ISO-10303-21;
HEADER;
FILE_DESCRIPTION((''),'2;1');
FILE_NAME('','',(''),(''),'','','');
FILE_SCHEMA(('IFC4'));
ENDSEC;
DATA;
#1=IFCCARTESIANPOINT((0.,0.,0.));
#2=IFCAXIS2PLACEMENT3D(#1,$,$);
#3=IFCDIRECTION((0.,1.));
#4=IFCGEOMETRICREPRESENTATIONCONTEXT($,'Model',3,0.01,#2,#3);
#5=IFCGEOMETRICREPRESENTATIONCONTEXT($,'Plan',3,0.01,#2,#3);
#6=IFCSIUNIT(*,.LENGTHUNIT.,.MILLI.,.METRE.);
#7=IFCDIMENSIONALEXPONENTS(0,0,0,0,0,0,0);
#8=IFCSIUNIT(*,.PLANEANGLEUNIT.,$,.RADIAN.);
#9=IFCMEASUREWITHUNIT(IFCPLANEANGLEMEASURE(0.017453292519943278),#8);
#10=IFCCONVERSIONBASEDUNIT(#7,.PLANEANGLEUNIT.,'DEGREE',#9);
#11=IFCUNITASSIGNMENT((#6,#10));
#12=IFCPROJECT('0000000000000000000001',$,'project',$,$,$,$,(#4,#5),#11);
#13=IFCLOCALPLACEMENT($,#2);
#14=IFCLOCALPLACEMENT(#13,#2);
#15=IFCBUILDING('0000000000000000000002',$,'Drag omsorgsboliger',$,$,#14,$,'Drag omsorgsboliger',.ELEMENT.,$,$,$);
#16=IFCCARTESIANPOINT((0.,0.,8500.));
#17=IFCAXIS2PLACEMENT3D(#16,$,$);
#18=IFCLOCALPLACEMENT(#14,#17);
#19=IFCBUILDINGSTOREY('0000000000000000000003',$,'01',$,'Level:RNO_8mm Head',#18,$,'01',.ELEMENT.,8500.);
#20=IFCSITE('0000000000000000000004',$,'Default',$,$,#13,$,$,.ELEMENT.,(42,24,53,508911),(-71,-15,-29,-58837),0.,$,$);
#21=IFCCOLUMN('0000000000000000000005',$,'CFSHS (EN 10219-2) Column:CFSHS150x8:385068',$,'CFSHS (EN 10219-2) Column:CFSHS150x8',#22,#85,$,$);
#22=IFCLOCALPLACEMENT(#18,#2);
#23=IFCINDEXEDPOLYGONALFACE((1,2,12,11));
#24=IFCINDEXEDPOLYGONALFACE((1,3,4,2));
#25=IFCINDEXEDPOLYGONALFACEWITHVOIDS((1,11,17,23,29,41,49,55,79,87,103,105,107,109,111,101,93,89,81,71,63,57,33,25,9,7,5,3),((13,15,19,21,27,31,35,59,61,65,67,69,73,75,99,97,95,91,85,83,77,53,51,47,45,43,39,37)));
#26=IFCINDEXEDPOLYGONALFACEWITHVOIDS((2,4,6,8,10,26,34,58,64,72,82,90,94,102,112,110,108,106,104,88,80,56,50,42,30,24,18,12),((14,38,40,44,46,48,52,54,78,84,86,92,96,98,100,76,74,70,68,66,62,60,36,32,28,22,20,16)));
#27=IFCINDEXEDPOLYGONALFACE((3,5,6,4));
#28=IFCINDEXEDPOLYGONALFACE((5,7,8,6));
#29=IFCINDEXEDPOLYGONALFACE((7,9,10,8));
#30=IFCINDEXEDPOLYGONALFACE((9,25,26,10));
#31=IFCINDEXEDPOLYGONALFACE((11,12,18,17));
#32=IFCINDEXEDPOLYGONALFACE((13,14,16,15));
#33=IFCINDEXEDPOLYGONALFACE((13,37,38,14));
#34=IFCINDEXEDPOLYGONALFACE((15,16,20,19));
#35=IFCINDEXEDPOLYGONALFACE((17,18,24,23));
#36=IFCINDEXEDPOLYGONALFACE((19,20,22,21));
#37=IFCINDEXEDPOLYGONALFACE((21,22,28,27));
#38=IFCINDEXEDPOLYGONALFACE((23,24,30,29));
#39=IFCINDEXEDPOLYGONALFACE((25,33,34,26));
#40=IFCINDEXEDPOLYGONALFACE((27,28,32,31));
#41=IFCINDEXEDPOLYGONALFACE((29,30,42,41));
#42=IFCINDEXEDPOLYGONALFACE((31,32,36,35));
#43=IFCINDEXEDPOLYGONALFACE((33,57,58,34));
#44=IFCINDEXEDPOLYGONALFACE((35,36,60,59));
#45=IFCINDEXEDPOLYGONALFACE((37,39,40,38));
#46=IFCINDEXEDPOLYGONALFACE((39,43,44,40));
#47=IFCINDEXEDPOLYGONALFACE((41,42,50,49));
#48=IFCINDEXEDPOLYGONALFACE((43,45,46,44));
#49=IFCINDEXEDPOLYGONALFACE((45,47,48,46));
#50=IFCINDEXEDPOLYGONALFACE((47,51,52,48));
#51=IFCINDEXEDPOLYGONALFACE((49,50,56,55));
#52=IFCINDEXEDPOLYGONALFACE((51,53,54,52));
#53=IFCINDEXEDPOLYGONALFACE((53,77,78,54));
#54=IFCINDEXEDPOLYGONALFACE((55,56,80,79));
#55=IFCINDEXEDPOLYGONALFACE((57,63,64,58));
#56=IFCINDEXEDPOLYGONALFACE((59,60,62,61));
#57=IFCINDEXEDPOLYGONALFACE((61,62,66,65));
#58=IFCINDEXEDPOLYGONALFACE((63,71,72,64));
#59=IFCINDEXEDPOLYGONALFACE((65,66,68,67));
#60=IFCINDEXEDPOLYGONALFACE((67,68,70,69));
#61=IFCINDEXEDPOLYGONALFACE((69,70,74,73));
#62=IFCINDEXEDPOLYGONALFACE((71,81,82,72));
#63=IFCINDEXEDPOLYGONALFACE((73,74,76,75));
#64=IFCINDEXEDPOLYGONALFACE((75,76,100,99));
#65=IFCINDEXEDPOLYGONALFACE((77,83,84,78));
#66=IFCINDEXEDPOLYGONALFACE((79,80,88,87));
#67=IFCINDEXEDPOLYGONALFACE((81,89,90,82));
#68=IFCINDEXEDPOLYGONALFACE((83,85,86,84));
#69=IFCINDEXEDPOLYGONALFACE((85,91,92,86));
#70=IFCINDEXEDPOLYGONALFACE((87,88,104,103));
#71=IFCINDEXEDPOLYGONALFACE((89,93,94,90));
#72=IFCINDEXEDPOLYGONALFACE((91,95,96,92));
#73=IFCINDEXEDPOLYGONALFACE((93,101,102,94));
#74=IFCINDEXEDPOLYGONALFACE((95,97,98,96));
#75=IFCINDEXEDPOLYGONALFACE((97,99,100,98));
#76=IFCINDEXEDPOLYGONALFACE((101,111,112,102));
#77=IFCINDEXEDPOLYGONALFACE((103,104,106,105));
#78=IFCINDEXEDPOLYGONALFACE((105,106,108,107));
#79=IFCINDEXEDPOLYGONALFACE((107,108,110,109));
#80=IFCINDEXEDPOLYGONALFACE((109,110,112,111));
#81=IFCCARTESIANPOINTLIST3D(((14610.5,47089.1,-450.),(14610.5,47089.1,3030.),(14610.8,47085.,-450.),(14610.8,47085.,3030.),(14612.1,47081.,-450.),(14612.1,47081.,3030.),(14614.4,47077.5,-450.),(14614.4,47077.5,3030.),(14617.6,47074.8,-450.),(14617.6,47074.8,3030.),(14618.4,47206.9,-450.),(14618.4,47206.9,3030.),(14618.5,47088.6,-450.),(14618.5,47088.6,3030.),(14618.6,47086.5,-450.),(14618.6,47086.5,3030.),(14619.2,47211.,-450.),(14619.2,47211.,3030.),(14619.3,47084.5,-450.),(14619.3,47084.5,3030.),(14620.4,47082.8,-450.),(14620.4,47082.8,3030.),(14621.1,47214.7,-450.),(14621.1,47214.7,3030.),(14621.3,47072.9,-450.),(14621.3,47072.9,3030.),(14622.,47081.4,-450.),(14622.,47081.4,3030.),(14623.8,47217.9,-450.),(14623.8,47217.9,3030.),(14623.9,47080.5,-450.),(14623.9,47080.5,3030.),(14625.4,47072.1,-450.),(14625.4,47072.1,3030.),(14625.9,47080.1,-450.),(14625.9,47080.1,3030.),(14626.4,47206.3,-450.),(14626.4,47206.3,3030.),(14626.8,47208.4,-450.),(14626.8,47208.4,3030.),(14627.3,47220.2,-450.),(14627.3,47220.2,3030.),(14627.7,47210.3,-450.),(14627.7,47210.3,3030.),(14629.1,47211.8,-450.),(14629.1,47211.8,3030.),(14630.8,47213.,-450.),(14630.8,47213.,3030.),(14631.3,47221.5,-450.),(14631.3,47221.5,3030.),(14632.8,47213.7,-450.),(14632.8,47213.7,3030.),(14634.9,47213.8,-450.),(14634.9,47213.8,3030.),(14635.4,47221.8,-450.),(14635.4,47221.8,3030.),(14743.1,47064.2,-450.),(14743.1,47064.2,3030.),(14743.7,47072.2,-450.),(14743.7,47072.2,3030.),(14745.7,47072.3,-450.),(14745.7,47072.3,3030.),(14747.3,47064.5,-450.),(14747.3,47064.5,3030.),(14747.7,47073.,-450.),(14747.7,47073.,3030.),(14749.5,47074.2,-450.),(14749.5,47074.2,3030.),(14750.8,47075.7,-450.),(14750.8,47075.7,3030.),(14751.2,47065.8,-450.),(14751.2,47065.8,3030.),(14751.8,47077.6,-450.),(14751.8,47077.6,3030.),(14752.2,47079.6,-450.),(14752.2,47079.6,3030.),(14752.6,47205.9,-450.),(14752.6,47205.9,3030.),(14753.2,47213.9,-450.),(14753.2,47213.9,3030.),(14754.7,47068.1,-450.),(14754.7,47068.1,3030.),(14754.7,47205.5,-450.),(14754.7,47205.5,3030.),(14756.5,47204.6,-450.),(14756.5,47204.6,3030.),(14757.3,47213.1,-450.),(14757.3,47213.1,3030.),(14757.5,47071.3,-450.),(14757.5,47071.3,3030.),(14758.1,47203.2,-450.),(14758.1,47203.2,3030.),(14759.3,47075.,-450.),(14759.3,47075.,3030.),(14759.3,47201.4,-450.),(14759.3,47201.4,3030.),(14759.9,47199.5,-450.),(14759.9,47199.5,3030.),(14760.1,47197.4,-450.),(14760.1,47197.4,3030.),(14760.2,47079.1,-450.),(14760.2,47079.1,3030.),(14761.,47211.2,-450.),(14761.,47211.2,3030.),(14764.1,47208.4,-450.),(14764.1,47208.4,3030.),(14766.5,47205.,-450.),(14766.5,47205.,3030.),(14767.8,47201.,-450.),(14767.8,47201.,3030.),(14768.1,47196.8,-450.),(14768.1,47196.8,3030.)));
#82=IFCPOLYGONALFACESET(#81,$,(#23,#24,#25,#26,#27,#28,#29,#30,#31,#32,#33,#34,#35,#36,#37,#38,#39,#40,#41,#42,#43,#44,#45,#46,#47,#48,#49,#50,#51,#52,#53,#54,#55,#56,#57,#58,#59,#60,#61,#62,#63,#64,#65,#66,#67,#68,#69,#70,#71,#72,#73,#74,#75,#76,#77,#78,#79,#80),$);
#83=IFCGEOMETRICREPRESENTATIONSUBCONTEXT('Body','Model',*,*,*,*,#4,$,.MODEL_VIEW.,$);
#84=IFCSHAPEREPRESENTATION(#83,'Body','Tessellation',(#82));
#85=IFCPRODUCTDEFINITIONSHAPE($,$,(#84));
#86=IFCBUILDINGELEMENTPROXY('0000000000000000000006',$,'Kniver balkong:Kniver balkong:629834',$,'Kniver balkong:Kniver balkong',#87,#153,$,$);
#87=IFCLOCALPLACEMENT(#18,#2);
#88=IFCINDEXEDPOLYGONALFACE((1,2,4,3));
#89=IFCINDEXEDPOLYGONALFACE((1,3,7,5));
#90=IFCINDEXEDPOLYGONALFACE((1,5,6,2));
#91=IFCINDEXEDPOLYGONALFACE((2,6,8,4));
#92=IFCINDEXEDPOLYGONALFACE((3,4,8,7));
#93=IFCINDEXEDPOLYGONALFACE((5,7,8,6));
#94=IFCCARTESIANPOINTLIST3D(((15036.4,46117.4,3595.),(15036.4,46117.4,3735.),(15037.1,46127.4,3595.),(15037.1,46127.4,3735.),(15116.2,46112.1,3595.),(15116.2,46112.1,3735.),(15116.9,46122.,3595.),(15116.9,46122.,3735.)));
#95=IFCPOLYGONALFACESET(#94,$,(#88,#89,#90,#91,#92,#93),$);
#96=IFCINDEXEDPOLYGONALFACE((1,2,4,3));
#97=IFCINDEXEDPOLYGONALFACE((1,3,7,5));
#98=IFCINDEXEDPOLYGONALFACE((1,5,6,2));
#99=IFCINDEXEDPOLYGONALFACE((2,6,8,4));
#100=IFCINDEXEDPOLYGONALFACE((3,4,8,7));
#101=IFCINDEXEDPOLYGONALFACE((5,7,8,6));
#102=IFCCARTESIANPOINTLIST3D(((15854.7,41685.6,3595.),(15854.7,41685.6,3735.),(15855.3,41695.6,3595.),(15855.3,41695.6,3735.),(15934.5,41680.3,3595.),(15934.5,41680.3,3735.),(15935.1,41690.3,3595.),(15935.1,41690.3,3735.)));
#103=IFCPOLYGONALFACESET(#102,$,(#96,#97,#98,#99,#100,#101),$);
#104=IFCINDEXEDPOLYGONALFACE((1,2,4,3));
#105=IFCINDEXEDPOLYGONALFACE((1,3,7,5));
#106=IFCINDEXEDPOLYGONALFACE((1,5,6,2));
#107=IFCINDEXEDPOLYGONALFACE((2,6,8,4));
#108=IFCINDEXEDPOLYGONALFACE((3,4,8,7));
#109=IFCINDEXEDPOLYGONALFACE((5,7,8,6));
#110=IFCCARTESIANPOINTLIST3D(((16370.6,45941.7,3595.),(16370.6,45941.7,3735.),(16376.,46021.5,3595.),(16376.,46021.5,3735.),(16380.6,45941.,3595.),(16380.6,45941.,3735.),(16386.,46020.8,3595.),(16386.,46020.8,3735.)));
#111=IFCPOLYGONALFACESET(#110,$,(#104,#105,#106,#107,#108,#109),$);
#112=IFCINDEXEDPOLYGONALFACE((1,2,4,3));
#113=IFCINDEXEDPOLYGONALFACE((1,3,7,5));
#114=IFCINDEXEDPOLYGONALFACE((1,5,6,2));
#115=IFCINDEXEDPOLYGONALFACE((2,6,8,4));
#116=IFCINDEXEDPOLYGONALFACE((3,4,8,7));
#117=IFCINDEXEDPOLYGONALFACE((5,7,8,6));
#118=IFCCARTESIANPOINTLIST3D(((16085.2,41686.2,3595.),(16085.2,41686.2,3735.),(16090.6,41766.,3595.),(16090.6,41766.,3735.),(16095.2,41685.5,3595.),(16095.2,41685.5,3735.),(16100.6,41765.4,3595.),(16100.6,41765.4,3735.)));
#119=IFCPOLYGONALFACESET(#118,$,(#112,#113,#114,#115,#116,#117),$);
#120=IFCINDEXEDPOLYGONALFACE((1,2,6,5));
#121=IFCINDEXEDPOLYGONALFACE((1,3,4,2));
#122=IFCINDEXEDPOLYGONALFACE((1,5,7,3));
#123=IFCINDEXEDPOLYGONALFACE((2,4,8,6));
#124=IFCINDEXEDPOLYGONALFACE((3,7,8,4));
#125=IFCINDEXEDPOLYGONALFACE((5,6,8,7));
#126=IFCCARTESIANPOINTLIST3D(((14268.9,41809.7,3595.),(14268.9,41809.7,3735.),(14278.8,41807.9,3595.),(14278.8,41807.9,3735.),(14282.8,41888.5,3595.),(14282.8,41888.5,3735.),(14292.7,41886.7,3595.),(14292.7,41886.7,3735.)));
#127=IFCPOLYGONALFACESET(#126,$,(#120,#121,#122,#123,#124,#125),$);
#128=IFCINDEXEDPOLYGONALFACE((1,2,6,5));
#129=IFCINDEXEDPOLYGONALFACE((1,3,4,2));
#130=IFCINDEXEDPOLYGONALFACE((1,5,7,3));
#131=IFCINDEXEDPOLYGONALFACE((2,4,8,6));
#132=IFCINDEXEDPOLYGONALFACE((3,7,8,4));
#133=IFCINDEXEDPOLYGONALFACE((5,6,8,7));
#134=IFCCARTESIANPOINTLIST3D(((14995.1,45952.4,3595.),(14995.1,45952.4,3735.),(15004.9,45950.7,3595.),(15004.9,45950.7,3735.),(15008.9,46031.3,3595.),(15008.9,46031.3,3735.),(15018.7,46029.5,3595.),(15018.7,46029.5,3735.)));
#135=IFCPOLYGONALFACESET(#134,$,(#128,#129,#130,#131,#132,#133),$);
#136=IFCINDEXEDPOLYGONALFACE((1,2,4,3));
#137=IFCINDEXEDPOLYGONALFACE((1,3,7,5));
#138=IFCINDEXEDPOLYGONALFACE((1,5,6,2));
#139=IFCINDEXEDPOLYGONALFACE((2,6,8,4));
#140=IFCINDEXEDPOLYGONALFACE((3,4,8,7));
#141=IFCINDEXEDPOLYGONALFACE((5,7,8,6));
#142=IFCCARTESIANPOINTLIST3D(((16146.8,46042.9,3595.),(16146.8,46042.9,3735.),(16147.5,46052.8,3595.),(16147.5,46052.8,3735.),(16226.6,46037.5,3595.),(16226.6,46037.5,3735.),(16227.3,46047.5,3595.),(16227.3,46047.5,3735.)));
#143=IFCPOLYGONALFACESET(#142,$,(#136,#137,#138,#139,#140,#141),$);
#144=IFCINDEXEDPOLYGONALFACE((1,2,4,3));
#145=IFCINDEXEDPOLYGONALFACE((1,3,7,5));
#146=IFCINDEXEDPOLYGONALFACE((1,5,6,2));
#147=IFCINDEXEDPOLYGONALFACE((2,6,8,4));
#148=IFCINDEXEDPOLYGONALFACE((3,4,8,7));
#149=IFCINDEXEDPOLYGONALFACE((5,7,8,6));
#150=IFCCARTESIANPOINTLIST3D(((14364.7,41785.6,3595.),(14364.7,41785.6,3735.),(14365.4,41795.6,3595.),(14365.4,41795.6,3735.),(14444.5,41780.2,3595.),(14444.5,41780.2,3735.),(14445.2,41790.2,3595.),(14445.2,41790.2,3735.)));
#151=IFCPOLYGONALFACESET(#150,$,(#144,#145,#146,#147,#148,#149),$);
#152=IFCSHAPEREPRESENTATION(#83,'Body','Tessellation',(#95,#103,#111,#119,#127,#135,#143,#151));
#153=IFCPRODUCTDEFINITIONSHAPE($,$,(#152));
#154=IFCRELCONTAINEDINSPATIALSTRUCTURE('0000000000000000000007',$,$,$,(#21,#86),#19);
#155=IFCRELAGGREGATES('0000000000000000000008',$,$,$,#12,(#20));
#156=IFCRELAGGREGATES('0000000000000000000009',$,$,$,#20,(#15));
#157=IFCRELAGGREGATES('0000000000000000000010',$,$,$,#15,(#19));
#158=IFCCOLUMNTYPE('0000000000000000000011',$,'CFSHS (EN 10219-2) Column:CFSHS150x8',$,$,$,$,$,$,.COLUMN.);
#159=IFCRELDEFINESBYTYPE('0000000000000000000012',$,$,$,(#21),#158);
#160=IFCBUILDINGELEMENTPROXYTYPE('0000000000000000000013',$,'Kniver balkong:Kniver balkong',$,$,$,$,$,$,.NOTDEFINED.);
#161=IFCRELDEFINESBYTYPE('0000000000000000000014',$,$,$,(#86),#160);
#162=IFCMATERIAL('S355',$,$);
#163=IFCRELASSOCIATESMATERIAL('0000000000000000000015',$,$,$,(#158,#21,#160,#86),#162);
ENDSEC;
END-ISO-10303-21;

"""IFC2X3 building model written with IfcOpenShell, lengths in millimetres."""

from ifc_helpers import new_model, entity, si_unit, converted_unit, direction, frame, frame_2d, origin, place, context, subcontext, project, spatial, polyline, circle_curve, parameter, trimmed, segment, composite_curve, rectangle, outline, extrude, source, transform, mapped, material, type_object, type_shapes, element, save


model = new_model("IFC2X3")

# Units and contexts
model_context = context("Model", 3, precision=0.01, world=origin(), true_north=direction((0.0, 1.0)))
plan_context = context("Plan", 3, precision=0.01, world=origin(), true_north=direction((0.0, 1.0)))
body_context = subcontext(model_context, "Body", "Model", "MODEL_VIEW")
ifc_project = project(units=[si_unit("LENGTHUNIT", "METRE", prefix="MILLI"), converted_unit("PLANEANGLEUNIT", "DEGREE", entity("IfcPlaneAngleMeasure", 0.017453292519943278), si_unit("PLANEANGLEUNIT", "RADIAN"), dimensions=[0, 0, 0, 0, 0, 0, 0])], contexts=[model_context, plan_context])

# Site, building, storey
site_placement = place(None, origin())
site = spatial("IfcSite", under=ifc_project, at=site_placement, Name="Default", CompositionType="ELEMENT", RefLatitude=(42, 24, 53, 508911), RefLongitude=(-71, -15, -29, -58837), RefElevation=0.0)
building_placement = place(site_placement, origin())
building = spatial("IfcBuilding", under=site, at=building_placement, Name="Drag omsorgsboliger", LongName="Drag omsorgsboliger", CompositionType="ELEMENT")
storey_placement = place(building_placement, frame((0.0, 0.0, 8500.0)))
storey = spatial("IfcBuildingStorey", under=building, at=storey_placement, Name="01", ObjectType="Level:RNO_8mm Head", LongName="01", CompositionType="ELEMENT", Elevation=8500.0)

# Column
ifc_material = material(Name="S355")
column_type_1 = type_object("IfcColumnType", Name="CFSHS (EN 10219-2) Column:CFSHS150x8", PredefinedType="COLUMN", material=ifc_material)
shared_shape_1 = source(origin(), body_context, "Body", "SweptSolid", [
    extrude(outline(composite_curve([segment(polyline([(-59.0, -75.0), (59.0, -75.0)]), True, "CONTINUOUS"), segment(trimmed(circle_curve(frame_2d((59.0, -59.0), x_axis=(-1.0, 0.0)), 16.0), [parameter(90.0)], [parameter(180.0)], True, "PARAMETER"), True, "CONTINUOUS"), segment(polyline([(75.0, -59.0), (75.0, 59.0)]), True, "CONTINUOUS"), segment(trimmed(circle_curve(frame_2d((59.0, 59.0), x_axis=(-1.0, 0.0)), 16.0), [parameter(180.0)], [parameter(270.0)], True, "PARAMETER"), True, "CONTINUOUS"), segment(polyline([(59.0, 75.0), (-59.0, 75.0)]), True, "CONTINUOUS"), segment(trimmed(circle_curve(frame_2d((-59.0, 59.0), x_axis=(-1.0, 0.0)), 16.0), [parameter(270.0)], [parameter(360.0)], True, "PARAMETER"), True, "CONTINUOUS"), segment(polyline([(-75.0, 59.0), (-75.0, -59.0)]), True, "CONTINUOUS"), segment(trimmed(circle_curve(frame_2d((-59.0, -59.0), x_axis=(-1.0, 0.0)), 16.0), [parameter(360.0)], [parameter(90.0)], True, "PARAMETER"), True, "CONTINUOUS")], self_intersect=False), holes=[composite_curve([segment(trimmed(circle_curve(frame_2d((-59.0, -59.0), x_axis=(-1.0, 0.0)), 8.0), [parameter(360.0)], [parameter(90.0)], True, "PARAMETER"), False, "CONTINUOUS"), segment(polyline([(-67.0, -59.0), (-67.0, 59.0)]), True, "CONTINUOUS"), segment(trimmed(circle_curve(frame_2d((-59.0, 59.0), x_axis=(-1.0, 0.0)), 8.0), [parameter(270.0)], [parameter(360.0)], True, "PARAMETER"), False, "CONTINUOUS"), segment(polyline([(-59.0, 67.0), (59.0, 67.0)]), True, "CONTINUOUS"), segment(trimmed(circle_curve(frame_2d((59.0, 59.0), x_axis=(-1.0, 0.0)), 8.0), [parameter(180.0)], [parameter(270.0)], True, "PARAMETER"), False, "CONTINUOUS"), segment(polyline([(67.0, 59.0), (67.0, -59.0)]), True, "CONTINUOUS"), segment(trimmed(circle_curve(frame_2d((59.0, -59.0), x_axis=(-1.0, 0.0)), 8.0), [parameter(90.0)], [parameter(180.0)], True, "PARAMETER"), False, "CONTINUOUS"), segment(polyline([(59.0, -67.0), (-59.0, -67.0)]), True, "CONTINUOUS")], self_intersect=False)]), frame((14689.3, 47143.0, 8050.0), z_axis=(0.0, 0.0, 1.0), x_axis=(-0.997758, 0.066923, 0.0)), (0.0, 0.0, 1.0), 3480.0),
])
type_shapes(column_type_1, [shared_shape_1])
column_1_placement = place(storey_placement, frame((0.0, 0.0, -8500.0)))
element("IfcColumn", 1, at=column_1_placement, inside=storey, type_object=column_type_1, material=ifc_material, Name="CFSHS (EN 10219-2) Column:CFSHS150x8:385068", ObjectType="CFSHS (EN 10219-2) Column:CFSHS150x8", context=body_context, shape_type="MappedRepresentation", body=[
    mapped(shared_shape_1, transform((0.0, 0.0, 0.0), scale=1.0)),
])

# Building element proxy
building_element_proxy_type_1 = type_object("IfcBuildingElementProxyType", Name="Kniver balkong:Kniver balkong", PredefinedType="NOTDEFINED", material=ifc_material)
shared_shape_2 = source(origin(), body_context, "Body", "SweptSolid", [
    extrude(rectangle(XDim=10.0, YDim=80.0, at=frame_2d((0.0, 0.0), x_axis=(1.0, 0.0))), frame((15076.7, 46119.7, 12095.0), z_axis=(0.0, 0.0, 1.0), x_axis=(0.066923, 0.997758, 0.0)), (0.0, 0.0, 1.0), 140.0),
    extrude(rectangle(XDim=10.0, YDim=80.0, at=frame_2d((0.0, 0.0), x_axis=(1.0, 0.0))), frame((15894.9, 41688.0, 12095.0), z_axis=(0.0, 0.0, 1.0), x_axis=(0.066923, 0.997758, 0.0)), (0.0, 0.0, 1.0), 140.0),
    extrude(rectangle(XDim=80.0, YDim=10.0, at=frame_2d((0.0, 0.0), x_axis=(1.0, 0.0))), frame((16378.3, 45981.2, 12095.0), z_axis=(0.0, 0.0, 1.0), x_axis=(0.066923, 0.997758, 0.0)), (0.0, 0.0, 1.0), 140.0),
    extrude(rectangle(XDim=80.0, YDim=10.0, at=frame_2d((0.0, 0.0), x_axis=(1.0, 0.0))), frame((16092.9, 41725.8, 12095.0), z_axis=(0.0, 0.0, 1.0), x_axis=(0.066923, 0.997758, 0.0)), (0.0, 0.0, 1.0), 140.0),
    extrude(rectangle(XDim=80.0, YDim=10.0, at=frame_2d((0.0, 0.0), x_axis=(1.0, 0.0))), frame((14280.8, 41848.2, 12095.0), z_axis=(0.0, 0.0, 1.0), x_axis=(0.173601, 0.984816, 0.0)), (0.0, 0.0, 1.0), 140.0),
    extrude(rectangle(XDim=80.0, YDim=10.0, at=frame_2d((0.0, 0.0), x_axis=(1.0, 0.0))), frame((15006.9, 45991.0, 12095.0), z_axis=(0.0, 0.0, 1.0), x_axis=(0.172091, 0.985081, 0.0)), (0.0, 0.0, 1.0), 140.0),
    extrude(rectangle(XDim=10.0, YDim=80.0, at=frame_2d((0.0, 0.0), x_axis=(1.0, 0.0))), frame((16187.1, 46045.2, 12095.0), z_axis=(0.0, 0.0, 1.0), x_axis=(0.066923, 0.997758, 0.0)), (0.0, 0.0, 1.0), 140.0),
    extrude(rectangle(XDim=10.0, YDim=80.0, at=frame_2d((0.0, 0.0), x_axis=(1.0, 0.0))), frame((14405.0, 41787.9, 12095.0), z_axis=(0.0, 0.0, 1.0), x_axis=(0.066923, 0.997758, 0.0)), (0.0, 0.0, 1.0), 140.0),
])
type_shapes(building_element_proxy_type_1, [shared_shape_2])
proxy_1_placement = place(storey_placement, frame((0.0, 0.0, -8500.0)))
element("IfcBuildingElementProxy", 2, at=proxy_1_placement, inside=storey, type_object=building_element_proxy_type_1, material=ifc_material, Name="Kniver balkong:Kniver balkong:629834", ObjectType="Kniver balkong:Kniver balkong", context=body_context, shape_type="MappedRepresentation", body=[
    mapped(shared_shape_2, transform((0.0, 0.0, 0.0), scale=1.0)),
])

save(model, "model.ifc")
